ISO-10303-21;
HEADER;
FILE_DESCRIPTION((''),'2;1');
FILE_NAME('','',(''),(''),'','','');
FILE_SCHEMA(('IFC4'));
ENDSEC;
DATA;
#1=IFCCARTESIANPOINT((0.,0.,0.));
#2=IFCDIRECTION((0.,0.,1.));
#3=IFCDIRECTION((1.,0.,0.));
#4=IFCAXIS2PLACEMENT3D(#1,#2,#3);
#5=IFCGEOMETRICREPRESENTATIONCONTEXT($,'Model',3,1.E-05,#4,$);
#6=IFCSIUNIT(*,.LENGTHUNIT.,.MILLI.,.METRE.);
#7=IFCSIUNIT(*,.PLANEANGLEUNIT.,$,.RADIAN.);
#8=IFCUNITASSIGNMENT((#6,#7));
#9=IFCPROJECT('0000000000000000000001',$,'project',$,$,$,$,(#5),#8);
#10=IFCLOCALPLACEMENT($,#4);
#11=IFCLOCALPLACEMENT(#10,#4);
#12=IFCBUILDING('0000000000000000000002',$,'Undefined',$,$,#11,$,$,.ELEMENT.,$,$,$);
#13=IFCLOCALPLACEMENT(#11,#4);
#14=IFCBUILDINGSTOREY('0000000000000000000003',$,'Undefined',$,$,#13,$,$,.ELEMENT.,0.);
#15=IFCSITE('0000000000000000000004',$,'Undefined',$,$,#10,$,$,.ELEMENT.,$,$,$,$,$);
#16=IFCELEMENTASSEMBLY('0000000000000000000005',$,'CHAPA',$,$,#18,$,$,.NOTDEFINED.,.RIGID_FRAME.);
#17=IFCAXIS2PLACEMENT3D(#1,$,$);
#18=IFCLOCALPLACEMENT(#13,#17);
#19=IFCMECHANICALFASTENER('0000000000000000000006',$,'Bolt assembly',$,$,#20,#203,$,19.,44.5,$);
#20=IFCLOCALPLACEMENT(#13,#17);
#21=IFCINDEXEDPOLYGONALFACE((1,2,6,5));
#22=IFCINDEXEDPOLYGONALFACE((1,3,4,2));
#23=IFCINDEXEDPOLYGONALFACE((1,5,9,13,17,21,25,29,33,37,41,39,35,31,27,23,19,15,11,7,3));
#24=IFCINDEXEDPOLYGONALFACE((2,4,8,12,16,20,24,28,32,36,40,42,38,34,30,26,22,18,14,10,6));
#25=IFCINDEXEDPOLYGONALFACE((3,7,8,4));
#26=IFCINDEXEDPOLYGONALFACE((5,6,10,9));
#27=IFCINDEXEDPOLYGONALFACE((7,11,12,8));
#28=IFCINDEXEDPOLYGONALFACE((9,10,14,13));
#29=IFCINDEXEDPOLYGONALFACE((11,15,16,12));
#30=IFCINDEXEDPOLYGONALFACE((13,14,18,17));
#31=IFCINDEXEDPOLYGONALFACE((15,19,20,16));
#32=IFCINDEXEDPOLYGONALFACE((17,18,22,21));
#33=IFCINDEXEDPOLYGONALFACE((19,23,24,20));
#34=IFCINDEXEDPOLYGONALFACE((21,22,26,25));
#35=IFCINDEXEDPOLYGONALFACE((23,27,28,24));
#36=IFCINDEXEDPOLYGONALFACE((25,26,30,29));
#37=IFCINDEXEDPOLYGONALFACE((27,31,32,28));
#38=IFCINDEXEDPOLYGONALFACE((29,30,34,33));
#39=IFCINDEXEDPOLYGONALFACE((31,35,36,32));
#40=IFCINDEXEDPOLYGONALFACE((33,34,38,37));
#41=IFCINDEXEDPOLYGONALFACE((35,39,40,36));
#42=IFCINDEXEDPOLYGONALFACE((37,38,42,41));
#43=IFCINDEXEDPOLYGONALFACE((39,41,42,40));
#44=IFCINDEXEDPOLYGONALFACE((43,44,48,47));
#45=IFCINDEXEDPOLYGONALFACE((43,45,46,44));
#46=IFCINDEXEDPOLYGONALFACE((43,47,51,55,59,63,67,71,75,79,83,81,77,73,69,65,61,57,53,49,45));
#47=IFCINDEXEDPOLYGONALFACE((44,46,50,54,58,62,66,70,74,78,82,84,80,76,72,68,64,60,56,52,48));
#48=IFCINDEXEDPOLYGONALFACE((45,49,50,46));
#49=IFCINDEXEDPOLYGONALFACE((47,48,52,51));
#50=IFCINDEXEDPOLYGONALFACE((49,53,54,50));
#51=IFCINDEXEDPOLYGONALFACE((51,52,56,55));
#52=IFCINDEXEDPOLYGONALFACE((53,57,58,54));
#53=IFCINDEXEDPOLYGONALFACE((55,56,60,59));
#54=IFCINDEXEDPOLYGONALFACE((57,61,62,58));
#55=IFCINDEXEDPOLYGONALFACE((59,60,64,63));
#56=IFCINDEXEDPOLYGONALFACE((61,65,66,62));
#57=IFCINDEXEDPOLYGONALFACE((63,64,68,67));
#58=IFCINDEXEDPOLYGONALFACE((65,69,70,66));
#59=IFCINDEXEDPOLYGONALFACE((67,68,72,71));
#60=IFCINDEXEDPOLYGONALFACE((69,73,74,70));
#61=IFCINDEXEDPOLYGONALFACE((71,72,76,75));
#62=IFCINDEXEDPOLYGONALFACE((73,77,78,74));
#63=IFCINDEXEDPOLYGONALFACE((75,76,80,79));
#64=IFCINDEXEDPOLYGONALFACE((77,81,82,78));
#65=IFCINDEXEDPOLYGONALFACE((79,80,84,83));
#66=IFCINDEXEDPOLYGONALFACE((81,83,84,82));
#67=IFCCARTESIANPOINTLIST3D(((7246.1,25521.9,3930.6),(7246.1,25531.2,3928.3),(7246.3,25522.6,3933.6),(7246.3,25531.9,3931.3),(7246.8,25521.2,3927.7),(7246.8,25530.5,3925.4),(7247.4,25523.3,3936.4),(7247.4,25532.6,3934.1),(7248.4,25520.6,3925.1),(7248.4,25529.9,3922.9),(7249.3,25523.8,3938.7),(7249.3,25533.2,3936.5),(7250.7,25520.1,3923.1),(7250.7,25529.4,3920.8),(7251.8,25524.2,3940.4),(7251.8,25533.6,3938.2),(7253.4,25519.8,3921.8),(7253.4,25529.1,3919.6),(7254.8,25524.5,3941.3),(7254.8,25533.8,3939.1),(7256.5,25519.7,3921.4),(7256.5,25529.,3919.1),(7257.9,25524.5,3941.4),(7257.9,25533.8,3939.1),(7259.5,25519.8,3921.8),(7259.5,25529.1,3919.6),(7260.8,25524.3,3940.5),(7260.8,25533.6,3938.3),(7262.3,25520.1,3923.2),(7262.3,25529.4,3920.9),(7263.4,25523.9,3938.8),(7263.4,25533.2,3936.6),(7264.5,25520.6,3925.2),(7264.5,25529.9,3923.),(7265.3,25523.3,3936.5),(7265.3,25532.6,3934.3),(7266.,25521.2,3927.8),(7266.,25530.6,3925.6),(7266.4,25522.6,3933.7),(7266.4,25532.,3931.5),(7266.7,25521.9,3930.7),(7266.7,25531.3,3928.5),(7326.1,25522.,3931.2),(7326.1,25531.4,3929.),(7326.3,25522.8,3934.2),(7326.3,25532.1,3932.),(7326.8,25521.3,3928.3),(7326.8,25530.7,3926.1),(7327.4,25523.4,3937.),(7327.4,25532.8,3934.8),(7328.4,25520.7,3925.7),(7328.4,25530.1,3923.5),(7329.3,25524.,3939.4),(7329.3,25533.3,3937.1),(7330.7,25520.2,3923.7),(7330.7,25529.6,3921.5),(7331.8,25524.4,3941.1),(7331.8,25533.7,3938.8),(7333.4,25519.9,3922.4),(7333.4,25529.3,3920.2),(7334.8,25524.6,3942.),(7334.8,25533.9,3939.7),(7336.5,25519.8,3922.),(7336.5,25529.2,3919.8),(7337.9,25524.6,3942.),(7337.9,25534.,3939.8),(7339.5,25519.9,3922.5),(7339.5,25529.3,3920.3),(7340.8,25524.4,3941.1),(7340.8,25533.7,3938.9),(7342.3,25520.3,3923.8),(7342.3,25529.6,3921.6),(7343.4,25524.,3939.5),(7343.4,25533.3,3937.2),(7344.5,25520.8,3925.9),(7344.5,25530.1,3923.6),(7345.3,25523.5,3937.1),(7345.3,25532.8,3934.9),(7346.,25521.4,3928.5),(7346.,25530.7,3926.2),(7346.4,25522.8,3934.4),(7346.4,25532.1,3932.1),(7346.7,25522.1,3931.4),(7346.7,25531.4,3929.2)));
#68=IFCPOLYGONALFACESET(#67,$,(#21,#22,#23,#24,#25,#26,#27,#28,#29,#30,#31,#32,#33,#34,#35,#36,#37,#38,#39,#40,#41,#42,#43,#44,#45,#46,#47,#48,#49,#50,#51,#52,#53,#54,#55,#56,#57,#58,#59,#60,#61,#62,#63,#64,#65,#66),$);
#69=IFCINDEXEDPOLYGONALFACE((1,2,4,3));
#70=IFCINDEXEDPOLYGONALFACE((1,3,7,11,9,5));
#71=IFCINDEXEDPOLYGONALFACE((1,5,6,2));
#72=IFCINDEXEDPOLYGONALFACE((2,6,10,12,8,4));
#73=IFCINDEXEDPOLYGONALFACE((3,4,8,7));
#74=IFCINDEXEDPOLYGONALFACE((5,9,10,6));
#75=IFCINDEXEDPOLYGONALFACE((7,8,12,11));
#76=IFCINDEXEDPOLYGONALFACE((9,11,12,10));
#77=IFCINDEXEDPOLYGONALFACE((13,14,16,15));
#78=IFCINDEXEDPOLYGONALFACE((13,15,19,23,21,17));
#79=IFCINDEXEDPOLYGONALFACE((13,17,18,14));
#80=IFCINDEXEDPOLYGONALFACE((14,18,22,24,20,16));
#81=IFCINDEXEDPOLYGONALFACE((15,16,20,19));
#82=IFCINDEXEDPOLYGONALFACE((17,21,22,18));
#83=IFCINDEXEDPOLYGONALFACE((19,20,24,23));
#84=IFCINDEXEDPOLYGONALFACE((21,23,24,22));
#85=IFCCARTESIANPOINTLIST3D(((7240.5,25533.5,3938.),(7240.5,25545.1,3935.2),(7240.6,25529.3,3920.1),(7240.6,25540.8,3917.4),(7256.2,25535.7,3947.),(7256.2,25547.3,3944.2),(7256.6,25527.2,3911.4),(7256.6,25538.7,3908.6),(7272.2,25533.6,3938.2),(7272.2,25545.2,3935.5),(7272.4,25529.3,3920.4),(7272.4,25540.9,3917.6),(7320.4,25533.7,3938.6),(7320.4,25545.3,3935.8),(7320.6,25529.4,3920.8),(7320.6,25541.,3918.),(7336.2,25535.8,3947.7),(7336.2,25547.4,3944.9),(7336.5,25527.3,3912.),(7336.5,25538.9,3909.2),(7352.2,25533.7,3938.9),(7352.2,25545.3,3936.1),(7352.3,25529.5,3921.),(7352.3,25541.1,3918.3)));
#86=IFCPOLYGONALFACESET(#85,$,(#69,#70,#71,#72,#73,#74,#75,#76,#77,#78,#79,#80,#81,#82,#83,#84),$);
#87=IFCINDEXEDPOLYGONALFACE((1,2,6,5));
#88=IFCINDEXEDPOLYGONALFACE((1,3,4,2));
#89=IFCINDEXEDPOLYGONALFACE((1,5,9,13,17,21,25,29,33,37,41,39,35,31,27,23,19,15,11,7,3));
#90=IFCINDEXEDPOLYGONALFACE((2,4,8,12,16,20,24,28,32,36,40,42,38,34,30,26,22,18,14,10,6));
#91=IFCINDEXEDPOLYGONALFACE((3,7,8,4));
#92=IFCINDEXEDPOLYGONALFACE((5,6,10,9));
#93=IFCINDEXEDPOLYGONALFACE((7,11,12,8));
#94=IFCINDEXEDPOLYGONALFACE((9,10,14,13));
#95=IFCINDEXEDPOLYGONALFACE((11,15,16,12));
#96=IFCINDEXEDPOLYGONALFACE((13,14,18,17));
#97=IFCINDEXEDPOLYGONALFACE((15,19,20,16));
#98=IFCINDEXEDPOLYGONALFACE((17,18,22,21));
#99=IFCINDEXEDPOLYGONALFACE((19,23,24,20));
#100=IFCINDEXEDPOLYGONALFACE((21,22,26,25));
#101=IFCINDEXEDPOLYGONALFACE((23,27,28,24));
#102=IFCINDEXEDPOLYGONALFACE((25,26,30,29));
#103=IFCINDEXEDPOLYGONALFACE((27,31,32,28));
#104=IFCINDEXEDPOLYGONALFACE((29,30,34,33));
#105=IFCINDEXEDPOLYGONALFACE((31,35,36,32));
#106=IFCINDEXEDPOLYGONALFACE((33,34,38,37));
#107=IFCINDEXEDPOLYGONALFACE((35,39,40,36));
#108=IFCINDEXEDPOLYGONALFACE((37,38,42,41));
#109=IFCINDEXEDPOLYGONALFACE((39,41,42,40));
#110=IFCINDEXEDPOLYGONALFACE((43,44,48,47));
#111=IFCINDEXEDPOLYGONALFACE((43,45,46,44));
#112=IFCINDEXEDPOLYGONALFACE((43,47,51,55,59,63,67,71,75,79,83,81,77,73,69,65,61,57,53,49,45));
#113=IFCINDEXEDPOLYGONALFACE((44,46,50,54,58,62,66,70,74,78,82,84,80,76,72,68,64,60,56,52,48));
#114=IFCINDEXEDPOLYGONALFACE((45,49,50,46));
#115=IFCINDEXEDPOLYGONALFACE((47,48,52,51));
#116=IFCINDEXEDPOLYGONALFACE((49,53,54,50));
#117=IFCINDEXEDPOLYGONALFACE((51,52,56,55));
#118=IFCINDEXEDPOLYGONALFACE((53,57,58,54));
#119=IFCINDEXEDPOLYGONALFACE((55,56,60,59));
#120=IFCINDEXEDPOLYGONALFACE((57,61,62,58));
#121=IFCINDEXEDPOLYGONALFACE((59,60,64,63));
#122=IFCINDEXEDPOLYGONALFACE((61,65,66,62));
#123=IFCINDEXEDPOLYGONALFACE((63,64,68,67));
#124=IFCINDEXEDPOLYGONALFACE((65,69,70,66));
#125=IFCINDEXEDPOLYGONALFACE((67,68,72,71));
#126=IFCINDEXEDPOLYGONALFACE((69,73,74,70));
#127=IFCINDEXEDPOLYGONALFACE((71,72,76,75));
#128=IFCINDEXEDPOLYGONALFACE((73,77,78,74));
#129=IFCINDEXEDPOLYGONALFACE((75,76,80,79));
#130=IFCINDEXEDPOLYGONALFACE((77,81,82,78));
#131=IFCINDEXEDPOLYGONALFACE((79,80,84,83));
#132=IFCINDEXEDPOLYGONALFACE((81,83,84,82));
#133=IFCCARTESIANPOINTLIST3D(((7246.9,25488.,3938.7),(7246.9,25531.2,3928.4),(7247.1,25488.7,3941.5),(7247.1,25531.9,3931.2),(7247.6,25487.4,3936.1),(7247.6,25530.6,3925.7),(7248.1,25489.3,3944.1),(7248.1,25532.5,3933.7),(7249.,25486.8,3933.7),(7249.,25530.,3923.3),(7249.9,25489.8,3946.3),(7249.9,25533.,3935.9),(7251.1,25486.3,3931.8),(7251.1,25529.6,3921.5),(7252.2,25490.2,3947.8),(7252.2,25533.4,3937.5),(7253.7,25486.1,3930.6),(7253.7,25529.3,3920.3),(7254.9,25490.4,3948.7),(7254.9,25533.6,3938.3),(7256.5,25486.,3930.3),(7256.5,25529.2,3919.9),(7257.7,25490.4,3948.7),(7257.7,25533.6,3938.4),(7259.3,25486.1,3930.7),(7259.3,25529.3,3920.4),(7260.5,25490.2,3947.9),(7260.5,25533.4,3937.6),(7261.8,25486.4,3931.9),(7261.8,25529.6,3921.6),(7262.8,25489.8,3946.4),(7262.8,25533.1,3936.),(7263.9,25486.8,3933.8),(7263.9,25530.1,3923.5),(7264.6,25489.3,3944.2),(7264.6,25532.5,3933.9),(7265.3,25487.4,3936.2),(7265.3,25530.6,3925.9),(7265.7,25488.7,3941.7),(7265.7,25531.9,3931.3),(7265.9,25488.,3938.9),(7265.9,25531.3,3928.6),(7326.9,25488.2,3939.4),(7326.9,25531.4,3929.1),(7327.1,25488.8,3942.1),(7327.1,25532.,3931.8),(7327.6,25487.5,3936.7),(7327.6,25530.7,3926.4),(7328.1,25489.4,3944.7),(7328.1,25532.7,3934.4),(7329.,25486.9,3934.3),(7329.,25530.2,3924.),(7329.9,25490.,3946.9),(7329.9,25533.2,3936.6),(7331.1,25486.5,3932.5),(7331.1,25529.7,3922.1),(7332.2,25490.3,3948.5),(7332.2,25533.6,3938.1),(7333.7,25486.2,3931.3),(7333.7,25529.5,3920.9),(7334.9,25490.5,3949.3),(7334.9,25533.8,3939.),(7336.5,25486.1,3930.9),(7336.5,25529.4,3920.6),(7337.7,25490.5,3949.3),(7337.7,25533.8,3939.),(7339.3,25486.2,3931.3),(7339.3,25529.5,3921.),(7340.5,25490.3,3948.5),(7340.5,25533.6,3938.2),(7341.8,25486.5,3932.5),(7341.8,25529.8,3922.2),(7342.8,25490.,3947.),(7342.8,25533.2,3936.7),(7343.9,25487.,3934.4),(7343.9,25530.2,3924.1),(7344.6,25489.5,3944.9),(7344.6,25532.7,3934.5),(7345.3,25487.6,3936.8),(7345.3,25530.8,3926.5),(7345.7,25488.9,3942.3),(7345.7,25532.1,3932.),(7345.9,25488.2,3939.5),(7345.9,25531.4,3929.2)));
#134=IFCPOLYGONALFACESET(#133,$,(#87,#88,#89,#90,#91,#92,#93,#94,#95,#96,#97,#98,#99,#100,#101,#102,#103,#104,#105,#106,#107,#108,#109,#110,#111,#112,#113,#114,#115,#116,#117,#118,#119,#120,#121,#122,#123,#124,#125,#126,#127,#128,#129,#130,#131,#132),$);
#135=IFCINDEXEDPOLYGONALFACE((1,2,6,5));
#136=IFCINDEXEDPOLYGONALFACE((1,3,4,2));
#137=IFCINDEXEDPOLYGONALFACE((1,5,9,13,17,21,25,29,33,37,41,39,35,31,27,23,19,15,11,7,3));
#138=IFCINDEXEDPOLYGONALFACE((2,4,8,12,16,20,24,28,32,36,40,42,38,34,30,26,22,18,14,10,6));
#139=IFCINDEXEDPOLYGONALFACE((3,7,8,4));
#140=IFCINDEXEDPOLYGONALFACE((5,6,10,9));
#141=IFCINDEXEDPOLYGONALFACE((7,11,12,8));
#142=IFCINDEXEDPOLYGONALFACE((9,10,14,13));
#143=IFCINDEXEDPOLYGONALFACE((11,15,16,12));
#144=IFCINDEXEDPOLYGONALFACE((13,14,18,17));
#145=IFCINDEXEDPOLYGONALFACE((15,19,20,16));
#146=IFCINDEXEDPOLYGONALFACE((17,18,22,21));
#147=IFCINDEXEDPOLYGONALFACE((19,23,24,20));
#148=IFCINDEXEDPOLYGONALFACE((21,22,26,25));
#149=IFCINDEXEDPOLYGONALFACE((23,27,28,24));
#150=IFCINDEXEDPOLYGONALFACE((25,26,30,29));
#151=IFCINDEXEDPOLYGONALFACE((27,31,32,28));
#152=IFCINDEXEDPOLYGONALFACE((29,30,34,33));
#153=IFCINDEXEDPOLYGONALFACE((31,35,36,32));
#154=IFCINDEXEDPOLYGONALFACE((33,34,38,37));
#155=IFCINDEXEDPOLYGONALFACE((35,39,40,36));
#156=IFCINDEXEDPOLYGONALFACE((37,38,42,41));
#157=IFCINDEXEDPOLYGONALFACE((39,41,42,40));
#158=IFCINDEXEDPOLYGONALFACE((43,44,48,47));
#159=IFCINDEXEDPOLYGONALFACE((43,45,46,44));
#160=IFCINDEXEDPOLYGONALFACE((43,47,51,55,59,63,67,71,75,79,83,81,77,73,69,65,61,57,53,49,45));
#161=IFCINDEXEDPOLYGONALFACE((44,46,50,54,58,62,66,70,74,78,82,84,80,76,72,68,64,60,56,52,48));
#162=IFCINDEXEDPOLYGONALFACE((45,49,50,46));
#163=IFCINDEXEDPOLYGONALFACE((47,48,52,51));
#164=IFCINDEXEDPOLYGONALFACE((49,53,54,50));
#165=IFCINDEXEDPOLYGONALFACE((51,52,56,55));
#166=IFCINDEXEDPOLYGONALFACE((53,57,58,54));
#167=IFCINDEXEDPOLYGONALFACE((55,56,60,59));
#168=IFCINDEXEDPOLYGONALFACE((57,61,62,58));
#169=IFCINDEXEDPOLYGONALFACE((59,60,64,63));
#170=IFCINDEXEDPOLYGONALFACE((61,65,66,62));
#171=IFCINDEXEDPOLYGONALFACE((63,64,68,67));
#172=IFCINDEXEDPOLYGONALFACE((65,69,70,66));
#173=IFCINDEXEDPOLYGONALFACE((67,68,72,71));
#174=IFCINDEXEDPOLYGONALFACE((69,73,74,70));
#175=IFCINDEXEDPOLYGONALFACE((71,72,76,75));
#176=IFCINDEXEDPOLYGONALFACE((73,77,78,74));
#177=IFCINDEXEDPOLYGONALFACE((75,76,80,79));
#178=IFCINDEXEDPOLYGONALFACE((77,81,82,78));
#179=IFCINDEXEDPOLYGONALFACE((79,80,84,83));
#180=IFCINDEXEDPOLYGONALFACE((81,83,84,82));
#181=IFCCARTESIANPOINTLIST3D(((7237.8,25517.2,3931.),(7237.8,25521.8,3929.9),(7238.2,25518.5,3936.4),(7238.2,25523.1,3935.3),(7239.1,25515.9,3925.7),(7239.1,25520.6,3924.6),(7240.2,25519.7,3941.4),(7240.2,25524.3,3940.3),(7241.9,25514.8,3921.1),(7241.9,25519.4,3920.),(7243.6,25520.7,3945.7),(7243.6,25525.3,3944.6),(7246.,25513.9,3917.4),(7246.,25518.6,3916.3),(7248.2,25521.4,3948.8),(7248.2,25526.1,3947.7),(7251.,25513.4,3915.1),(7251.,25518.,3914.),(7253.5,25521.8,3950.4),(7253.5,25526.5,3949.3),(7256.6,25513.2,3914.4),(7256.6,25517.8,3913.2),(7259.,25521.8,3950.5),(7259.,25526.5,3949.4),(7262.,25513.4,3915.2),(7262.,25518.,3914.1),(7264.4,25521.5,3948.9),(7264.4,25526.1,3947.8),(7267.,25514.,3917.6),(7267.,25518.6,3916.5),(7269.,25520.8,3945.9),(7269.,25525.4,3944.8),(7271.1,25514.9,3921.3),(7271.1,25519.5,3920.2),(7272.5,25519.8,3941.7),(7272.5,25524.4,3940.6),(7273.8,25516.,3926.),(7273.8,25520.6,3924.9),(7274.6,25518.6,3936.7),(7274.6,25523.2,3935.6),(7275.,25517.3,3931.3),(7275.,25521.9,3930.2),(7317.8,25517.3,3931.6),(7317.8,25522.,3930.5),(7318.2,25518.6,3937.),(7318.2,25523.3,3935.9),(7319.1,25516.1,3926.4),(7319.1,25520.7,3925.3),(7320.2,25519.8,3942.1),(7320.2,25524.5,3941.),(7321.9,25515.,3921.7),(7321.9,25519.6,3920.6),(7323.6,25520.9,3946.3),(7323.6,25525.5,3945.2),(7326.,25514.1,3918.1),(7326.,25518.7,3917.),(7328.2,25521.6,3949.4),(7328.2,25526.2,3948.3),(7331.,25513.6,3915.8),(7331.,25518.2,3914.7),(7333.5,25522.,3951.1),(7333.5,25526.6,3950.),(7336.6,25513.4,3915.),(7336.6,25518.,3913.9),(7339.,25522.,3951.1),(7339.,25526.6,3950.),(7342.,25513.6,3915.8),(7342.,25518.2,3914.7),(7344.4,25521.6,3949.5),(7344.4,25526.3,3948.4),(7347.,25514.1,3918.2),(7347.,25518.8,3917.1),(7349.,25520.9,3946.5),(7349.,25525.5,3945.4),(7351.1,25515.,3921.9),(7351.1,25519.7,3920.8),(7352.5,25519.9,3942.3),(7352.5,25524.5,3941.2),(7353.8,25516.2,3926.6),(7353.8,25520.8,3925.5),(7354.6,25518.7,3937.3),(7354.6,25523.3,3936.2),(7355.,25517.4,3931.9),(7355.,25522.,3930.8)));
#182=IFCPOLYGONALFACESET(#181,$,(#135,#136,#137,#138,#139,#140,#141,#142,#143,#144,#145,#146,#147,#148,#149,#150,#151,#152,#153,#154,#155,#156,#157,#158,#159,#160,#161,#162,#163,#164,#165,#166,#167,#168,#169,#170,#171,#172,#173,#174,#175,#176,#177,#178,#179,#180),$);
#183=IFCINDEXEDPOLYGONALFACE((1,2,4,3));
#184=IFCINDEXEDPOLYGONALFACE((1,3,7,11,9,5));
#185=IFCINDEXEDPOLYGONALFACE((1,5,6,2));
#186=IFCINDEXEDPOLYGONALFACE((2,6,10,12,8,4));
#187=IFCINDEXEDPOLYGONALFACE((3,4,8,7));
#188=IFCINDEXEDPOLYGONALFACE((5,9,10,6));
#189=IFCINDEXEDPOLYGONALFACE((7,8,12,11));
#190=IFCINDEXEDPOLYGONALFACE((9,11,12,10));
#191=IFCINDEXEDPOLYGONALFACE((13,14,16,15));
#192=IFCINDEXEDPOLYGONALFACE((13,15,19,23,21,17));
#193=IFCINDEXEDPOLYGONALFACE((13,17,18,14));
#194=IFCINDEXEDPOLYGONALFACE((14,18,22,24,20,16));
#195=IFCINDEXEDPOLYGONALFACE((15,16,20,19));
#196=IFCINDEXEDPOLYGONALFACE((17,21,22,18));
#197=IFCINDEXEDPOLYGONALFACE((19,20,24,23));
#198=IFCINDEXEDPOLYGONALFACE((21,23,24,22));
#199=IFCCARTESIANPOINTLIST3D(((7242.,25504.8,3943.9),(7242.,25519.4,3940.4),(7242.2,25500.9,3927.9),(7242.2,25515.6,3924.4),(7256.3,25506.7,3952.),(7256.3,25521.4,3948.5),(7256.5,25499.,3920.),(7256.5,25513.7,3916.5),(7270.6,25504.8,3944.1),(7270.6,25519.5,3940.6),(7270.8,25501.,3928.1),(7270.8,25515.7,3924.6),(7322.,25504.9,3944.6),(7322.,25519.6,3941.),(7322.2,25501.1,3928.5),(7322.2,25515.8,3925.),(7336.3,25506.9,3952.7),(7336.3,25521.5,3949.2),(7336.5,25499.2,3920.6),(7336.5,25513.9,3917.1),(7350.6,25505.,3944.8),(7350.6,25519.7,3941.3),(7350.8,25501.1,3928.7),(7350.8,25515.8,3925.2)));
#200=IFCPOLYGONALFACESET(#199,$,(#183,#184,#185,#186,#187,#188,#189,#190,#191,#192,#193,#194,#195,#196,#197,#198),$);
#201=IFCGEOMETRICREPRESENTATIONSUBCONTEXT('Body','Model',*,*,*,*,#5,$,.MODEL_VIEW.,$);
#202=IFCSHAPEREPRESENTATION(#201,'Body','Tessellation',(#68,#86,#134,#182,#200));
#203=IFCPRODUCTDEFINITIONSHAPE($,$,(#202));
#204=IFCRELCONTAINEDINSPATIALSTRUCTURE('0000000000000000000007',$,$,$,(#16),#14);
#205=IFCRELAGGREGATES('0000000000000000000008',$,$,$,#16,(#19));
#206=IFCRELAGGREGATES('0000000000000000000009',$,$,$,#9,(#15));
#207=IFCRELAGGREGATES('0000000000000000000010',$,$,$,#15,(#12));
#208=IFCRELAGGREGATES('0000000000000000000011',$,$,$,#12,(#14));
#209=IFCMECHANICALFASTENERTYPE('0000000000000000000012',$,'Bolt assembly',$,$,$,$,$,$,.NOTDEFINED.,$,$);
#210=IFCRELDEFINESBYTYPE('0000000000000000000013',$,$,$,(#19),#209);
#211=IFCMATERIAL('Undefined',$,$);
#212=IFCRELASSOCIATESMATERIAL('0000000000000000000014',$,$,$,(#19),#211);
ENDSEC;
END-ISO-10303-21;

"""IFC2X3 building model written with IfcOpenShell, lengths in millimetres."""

from ifc_helpers import new_model, si_unit, frame, origin_with_axes, origin_2d_with_axis, place, context, subcontext, project, spatial, polyline, circle, outline, extrude, source, transform, mapped, material, type_object, element, aggregate, save


model = new_model("IFC2X3")

# Units and contexts
model_context = context("Model", 3, precision=1e-05, world=origin_with_axes())
body_context = subcontext(model_context, "Body", "Model", "MODEL_VIEW")
ifc_project = project(units=[si_unit("LENGTHUNIT", "METRE", prefix="MILLI"), si_unit("PLANEANGLEUNIT", "RADIAN")], contexts=[model_context])

# Site, building, storey
site_placement = place(None, origin_with_axes())
site = spatial("IfcSite", under=ifc_project, at=site_placement, Name="Undefined", CompositionType="ELEMENT")
building_placement = place(site_placement, origin_with_axes())
building = spatial("IfcBuilding", under=site, at=building_placement, Name="Undefined", CompositionType="ELEMENT")
storey_placement = place(building_placement, origin_with_axes())
storey = spatial("IfcBuildingStorey", under=building, at=storey_placement, Name="Undefined", CompositionType="ELEMENT", Elevation=0.0)

# Element assembly
assembly_1_placement = place(storey_placement, origin_with_axes())
assembly_1 = element("IfcElementAssembly", 1, at=assembly_1_placement, inside=storey, Name="CHAPA", AssemblyPlace="NOTDEFINED", PredefinedType="RIGID_FRAME")

# Shared definitions
ifc_material_1 = material(Name="Undefined")
mechanical_fastener_type = type_object("IfcMechanicalFastenerType", Name="Bolt assembly")

# Mechanical fastener
shared_shape_1 = source(origin_with_axes(), body_context, "Body", "SweptSolid", [
    extrude(circle(Radius=10.3, at=origin_2d_with_axis()), frame((0.0, 0.0, 0.0), z_axis=(0.0, 1.0, 0.0), x_axis=(1.0, 0.0, 0.0)), (0.0, 0.0, 1.0), 9.6),
    extrude(outline(polyline([(18.3, 0.0), (9.2, 15.9), (-9.2, 15.9), (-18.3, 0.0), (-9.2, -15.9), (9.2, -15.9), (18.3, 0.0)])), frame((0.0, -11.9, 0.0), z_axis=(0.0, 1.0, 0.0), x_axis=(1.0, 0.0, 0.0)), (0.0, 0.0, 1.0), 11.9),
    extrude(circle(Radius=9.5, at=origin_2d_with_axis()), frame((0.0, 0.0, 0.0), z_axis=(0.0, 1.0, 0.0), x_axis=(1.0, 0.0, 0.0)), (0.0, 0.0, 1.0), 44.5),
    extrude(circle(Radius=18.7, at=origin_2d_with_axis()), frame((0.0, 9.5, 0.0), z_axis=(0.0, 1.0, 0.0), x_axis=(1.0, 0.0, 0.0)), (0.0, 0.0, 1.0), 4.8),
    extrude(outline(polyline([(16.5, 0.0), (8.2, 14.3), (-8.2, 14.3), (-16.5, 0.0), (-8.2, -14.3), (8.2, -14.3), (16.5, 0.0)])), frame((0.0, 14.3, 0.0), z_axis=(0.0, 1.0, 0.0), x_axis=(1.0, 0.0, 0.0)), (0.0, 0.0, 1.0), 15.1),
])
mechanical_fastener_1_placement = place(assembly_1_placement, frame((7296.4, 25531.5, 3929.5), z_axis=(-0.999966, -0.001919, -0.008026), x_axis=(0.008253, -0.23249, -0.972564)))
mechanical_fastener_1 = element("IfcMechanicalFastener", 2, at=mechanical_fastener_1_placement, type_object=mechanical_fastener_type, material=ifc_material_1, Name="Bolt assembly", NominalDiameter=19.0, NominalLength=44.5, context=body_context, shape_type="MappedRepresentation", body=[
    mapped(shared_shape_1, transform((0.0, 0.0, 40.0))),
    mapped(shared_shape_1, transform((0.0, 0.0, -40.0))),
])
aggregate(assembly_1, [mechanical_fastener_1])

save(model, "model.ifc")
